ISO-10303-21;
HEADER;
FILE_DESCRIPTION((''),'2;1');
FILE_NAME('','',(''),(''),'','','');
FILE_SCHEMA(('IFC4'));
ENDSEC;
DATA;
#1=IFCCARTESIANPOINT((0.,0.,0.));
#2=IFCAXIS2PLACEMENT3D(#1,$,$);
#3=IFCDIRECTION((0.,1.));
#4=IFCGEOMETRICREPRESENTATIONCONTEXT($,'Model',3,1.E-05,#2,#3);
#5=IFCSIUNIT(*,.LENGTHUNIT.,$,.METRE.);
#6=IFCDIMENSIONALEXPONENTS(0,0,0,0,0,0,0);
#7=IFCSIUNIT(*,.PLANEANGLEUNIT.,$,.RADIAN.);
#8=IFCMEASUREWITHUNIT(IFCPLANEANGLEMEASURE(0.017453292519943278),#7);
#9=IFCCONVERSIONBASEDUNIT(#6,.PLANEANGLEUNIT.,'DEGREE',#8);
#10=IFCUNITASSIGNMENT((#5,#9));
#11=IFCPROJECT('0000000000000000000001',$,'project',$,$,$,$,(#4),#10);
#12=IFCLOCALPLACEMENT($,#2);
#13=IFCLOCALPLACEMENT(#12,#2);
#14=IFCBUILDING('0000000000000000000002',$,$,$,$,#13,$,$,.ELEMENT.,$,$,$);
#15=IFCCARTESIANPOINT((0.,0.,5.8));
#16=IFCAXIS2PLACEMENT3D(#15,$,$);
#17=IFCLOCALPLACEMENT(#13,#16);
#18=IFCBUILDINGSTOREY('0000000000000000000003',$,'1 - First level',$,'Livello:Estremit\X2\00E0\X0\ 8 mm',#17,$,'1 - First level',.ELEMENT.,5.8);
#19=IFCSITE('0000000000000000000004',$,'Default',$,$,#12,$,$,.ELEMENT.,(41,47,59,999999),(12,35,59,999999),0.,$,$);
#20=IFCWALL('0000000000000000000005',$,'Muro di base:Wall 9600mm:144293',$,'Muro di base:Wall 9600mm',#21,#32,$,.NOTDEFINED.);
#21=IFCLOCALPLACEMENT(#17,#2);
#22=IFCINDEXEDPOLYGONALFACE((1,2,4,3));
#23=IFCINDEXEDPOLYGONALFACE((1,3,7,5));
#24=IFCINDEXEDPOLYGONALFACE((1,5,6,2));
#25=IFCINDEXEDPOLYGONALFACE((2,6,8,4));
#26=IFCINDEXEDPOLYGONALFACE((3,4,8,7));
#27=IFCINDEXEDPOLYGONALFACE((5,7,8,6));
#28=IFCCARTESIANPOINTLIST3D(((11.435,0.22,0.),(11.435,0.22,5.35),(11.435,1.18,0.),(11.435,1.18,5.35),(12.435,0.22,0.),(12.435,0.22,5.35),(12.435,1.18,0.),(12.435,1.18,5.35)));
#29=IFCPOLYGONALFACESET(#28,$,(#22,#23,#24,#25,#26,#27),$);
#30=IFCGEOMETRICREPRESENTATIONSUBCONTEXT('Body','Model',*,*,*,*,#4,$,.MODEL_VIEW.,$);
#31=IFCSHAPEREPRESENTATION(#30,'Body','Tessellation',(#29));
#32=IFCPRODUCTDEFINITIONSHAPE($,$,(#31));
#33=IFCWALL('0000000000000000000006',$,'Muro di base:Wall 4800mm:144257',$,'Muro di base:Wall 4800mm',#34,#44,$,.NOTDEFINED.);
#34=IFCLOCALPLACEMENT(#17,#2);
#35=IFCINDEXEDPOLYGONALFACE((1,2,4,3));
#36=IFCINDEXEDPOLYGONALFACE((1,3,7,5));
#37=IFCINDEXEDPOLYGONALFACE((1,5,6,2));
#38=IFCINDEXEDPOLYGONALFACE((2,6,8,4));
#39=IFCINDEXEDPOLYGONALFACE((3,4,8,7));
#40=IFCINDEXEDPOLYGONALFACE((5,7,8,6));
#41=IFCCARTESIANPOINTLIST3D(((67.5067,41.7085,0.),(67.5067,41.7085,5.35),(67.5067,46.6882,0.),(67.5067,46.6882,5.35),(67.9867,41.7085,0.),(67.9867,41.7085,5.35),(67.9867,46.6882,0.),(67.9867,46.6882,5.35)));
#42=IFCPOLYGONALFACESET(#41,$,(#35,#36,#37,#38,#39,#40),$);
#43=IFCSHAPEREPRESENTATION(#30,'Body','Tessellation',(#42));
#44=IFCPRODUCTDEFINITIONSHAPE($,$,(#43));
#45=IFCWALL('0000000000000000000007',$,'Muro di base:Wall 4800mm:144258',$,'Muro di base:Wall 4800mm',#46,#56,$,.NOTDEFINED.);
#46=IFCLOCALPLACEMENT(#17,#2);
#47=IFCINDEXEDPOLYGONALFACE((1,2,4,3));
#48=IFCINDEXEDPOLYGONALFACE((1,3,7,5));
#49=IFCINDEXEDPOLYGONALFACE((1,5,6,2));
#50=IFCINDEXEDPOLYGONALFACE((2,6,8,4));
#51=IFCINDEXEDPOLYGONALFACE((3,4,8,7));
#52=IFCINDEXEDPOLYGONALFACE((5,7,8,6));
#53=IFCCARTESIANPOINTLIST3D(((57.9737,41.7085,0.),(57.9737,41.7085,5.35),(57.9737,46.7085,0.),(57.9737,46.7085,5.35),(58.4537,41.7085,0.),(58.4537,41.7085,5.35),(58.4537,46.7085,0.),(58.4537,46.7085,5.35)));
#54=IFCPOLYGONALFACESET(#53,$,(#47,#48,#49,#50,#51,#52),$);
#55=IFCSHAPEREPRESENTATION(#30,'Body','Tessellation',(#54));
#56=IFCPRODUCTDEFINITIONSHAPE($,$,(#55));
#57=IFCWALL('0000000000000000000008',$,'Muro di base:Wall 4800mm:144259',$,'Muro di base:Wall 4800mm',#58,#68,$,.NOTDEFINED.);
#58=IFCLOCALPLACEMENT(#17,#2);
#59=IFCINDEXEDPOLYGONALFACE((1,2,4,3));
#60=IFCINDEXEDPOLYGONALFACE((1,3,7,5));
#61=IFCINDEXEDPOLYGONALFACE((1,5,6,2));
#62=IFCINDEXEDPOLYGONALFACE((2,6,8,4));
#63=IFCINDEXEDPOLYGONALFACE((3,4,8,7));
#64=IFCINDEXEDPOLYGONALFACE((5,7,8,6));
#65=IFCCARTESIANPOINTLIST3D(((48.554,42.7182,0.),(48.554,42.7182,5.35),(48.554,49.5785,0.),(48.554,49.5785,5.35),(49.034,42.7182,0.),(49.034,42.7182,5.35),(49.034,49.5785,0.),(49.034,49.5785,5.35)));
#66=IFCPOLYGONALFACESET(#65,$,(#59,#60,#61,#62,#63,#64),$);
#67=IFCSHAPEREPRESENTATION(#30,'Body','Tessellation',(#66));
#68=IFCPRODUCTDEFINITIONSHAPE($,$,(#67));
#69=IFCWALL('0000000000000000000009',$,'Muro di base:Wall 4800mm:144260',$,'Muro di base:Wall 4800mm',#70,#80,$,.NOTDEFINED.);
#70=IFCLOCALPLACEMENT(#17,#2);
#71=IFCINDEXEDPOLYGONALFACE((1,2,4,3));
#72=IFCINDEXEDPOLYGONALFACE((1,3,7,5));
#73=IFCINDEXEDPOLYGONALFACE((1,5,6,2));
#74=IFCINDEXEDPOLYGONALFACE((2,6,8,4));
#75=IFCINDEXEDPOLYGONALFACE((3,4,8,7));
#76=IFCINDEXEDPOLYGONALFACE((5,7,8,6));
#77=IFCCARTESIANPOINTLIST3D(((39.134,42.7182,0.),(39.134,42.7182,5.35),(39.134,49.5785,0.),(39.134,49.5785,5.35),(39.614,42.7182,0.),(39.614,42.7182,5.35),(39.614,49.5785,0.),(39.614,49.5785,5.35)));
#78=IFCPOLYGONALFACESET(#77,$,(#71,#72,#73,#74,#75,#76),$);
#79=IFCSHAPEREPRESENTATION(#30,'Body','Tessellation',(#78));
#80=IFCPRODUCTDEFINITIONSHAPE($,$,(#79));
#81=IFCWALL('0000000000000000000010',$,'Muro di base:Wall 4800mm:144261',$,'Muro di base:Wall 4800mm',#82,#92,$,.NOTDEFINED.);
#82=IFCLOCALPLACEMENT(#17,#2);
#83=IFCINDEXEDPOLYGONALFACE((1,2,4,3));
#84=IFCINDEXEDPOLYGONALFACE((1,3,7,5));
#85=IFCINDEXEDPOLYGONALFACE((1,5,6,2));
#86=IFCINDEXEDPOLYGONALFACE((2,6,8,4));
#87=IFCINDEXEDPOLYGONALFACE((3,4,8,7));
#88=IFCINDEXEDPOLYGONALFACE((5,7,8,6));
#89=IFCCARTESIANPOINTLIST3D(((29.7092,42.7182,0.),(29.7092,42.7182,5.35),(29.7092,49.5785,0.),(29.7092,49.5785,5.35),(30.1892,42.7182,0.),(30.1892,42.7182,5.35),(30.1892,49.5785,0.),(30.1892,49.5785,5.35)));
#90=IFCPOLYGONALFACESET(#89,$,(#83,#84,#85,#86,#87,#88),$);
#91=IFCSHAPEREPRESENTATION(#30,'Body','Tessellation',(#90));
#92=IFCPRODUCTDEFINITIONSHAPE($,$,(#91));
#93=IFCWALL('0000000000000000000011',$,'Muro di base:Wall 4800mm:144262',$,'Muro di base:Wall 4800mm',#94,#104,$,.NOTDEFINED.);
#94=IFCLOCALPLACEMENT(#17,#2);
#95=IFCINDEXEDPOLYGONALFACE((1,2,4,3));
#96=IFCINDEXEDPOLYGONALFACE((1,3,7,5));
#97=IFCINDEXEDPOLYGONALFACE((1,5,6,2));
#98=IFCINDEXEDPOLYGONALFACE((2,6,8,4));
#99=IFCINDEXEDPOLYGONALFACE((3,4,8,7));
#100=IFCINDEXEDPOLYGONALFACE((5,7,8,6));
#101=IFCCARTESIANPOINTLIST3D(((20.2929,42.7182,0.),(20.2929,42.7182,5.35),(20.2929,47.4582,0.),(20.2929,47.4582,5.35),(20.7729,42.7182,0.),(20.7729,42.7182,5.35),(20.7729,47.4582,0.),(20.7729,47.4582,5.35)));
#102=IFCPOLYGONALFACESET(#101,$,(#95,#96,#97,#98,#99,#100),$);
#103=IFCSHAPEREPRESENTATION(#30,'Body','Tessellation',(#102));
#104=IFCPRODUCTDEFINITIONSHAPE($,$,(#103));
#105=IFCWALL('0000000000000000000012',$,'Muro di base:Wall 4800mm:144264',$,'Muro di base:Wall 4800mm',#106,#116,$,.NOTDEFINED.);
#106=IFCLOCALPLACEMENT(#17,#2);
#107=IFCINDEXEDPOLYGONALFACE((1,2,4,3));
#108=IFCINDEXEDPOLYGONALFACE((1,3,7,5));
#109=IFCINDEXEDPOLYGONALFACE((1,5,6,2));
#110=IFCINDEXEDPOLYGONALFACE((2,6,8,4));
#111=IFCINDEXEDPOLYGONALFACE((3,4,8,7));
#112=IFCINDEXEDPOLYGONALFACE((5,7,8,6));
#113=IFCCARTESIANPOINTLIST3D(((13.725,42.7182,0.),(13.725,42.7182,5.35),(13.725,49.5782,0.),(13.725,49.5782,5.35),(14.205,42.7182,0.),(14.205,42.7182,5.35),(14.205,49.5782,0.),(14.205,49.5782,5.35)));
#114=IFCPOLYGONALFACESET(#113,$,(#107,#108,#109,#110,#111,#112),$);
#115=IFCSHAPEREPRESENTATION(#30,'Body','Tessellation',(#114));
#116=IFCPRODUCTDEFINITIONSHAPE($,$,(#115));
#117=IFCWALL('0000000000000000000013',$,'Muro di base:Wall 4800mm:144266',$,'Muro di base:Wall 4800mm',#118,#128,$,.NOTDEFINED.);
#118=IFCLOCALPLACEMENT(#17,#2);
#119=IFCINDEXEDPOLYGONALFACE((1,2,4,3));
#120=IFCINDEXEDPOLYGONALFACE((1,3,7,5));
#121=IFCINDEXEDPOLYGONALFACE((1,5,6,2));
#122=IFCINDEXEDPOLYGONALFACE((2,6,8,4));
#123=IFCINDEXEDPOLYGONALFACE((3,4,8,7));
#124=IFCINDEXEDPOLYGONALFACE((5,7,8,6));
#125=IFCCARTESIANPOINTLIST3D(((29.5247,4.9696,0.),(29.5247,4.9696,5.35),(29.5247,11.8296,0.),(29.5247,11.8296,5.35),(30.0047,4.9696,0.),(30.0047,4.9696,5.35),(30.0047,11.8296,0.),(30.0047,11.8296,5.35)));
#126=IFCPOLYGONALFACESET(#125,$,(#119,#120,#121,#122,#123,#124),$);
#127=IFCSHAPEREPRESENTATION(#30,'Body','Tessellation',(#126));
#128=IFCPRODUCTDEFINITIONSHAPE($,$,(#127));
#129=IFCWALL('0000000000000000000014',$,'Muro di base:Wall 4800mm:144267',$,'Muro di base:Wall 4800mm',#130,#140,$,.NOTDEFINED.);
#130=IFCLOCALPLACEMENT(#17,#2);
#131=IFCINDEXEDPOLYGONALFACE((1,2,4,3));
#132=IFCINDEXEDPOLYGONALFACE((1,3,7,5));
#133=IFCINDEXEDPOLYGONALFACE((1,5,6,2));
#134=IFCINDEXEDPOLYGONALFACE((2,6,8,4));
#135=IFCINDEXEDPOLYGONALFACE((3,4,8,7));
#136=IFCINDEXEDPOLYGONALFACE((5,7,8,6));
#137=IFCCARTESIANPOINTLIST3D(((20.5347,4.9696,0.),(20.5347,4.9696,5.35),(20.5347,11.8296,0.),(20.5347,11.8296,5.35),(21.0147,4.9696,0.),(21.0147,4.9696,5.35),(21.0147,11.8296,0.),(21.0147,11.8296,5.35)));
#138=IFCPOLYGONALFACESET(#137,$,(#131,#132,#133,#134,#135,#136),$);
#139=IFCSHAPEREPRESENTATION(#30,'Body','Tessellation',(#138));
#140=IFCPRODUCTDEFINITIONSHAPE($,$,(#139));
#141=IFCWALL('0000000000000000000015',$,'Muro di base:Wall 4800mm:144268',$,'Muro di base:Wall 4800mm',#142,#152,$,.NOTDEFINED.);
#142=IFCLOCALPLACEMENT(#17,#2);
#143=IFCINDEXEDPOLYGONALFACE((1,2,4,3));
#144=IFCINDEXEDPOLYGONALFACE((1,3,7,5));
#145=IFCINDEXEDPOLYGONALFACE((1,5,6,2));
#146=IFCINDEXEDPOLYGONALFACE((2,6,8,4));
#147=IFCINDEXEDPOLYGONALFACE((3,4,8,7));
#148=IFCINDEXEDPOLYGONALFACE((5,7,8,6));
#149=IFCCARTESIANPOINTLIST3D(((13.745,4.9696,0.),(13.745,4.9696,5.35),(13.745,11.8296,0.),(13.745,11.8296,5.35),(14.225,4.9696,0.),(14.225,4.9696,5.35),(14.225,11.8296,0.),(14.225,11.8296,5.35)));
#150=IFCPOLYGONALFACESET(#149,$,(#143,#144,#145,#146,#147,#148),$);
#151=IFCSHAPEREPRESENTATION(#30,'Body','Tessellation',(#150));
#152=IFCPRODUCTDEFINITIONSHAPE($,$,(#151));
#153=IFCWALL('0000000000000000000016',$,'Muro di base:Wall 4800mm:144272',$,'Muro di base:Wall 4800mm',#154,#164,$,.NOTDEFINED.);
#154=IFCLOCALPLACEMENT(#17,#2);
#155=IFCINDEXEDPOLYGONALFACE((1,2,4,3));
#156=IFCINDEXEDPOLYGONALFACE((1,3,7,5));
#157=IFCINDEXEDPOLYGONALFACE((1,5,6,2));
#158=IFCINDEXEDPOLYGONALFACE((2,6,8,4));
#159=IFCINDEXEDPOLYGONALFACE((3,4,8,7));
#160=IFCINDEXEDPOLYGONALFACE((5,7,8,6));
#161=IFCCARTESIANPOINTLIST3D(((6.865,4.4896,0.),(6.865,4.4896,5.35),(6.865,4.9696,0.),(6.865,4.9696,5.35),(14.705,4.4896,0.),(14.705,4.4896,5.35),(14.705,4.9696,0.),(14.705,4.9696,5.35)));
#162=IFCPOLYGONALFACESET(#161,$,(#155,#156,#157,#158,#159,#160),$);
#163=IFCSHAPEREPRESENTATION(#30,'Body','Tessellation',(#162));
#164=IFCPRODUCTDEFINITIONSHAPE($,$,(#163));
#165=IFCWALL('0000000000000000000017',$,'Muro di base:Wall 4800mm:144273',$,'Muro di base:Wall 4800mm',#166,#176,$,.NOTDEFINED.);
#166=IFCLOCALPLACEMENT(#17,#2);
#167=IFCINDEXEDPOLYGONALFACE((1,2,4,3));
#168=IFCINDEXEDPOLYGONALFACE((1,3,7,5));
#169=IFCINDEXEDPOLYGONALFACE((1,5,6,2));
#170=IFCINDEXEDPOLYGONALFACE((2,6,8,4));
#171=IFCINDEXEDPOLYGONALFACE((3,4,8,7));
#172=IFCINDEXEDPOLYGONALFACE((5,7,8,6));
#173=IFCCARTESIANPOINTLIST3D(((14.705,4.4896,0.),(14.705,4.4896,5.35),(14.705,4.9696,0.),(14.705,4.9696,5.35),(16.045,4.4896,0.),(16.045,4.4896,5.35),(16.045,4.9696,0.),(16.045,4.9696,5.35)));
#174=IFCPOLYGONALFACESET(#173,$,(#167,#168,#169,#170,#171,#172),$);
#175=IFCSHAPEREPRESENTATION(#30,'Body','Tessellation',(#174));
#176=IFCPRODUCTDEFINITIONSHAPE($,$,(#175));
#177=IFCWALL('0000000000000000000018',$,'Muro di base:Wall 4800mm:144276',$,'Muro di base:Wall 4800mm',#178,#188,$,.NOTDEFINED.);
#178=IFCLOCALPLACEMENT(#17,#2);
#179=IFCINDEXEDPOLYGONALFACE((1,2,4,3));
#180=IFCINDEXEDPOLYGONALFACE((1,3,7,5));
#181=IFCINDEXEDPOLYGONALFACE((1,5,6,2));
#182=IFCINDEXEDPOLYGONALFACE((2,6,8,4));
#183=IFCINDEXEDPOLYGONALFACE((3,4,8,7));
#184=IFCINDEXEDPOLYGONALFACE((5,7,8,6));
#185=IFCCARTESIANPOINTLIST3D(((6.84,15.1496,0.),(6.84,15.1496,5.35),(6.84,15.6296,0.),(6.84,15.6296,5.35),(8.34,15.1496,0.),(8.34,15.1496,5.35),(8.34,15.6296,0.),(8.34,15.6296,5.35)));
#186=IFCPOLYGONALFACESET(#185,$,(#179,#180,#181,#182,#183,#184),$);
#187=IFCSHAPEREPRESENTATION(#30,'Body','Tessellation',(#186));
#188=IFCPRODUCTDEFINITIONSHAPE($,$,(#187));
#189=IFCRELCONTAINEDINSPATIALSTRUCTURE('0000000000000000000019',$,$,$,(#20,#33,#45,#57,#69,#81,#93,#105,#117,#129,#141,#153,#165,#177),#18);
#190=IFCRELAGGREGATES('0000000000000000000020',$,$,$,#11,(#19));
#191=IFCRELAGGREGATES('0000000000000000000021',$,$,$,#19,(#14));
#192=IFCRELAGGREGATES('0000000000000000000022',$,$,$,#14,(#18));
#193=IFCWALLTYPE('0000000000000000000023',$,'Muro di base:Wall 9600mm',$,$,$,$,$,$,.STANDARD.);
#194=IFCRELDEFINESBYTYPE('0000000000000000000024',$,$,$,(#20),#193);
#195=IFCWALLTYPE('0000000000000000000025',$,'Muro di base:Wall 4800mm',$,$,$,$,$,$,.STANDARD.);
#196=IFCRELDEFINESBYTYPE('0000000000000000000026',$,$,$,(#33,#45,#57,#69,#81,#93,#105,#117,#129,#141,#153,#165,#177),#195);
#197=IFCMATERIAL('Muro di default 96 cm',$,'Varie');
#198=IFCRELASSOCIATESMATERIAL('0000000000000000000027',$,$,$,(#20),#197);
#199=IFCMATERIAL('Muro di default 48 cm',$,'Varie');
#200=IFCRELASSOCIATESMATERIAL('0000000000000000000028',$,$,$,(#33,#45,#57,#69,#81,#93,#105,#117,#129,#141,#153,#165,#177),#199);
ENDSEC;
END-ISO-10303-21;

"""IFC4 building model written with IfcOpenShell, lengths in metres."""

from ifc_helpers import new_model, entity, si_unit, converted_unit, direction, frame, origin, place, context, subcontext, project, spatial, indexed_curve, outline, extrude, material, type_object, element, save


model = new_model("IFC4")

# Units and contexts
model_context = context("Model", 3, precision=1e-05, world=origin(), true_north=direction((0.0, 1.0)))
body_context = subcontext(model_context, "Body", "Model", "MODEL_VIEW")
ifc_project = project(units=[si_unit("LENGTHUNIT", "METRE"), converted_unit("PLANEANGLEUNIT", "DEGREE", entity("IfcPlaneAngleMeasure", 0.017453292519943278), si_unit("PLANEANGLEUNIT", "RADIAN"), dimensions=[0, 0, 0, 0, 0, 0, 0])], contexts=[model_context])

# Site, building, storey
site_placement = place(None, origin())
site = spatial("IfcSite", under=ifc_project, at=site_placement, Name="Default", CompositionType="ELEMENT", RefLatitude=(41, 47, 59, 999999), RefLongitude=(12, 35, 59, 999999), RefElevation=0.0)
building_placement = place(site_placement, origin())
building = spatial("IfcBuilding", under=site, at=building_placement, CompositionType="ELEMENT")
storey_placement = place(building_placement, frame((0.0, 0.0, 5.8)))
storey = spatial("IfcBuildingStorey", under=building, at=storey_placement, Name="1 - First level", ObjectType="Livello:Estremità 8 mm", LongName="1 - First level", CompositionType="ELEMENT", Elevation=5.8)

# Walls
ifc_material_1 = material(Name="Muro di default 96 cm", Category="Varie")
wall_type_1 = type_object("IfcWallType", Name="Muro di base:Wall 9600mm", PredefinedType="STANDARD")
wall_1_placement = place(storey_placement, frame((12.435, 0.7, 0.0), z_axis=(0.0, 0.0, 1.0), x_axis=(-1.0, 0.0, 0.0)))
element("IfcWall", 1, at=wall_1_placement, inside=storey, type_object=wall_type_1, material=ifc_material_1, Name="Muro di base:Wall 9600mm:144293", ObjectType="Muro di base:Wall 9600mm", PredefinedType="NOTDEFINED", context=body_context, shape_type="SweptSolid", body=[
    extrude(outline(indexed_curve([(1.0, 0.48), (0.0, 0.48), (0.0, -0.48), (1.0, -0.48), (1.0, 0.48)], self_intersect=False)), origin(), (0.0, 0.0, 1.0), 5.35),
])
ifc_material_2 = material(Name="Muro di default 48 cm", Category="Varie")
wall_type_2 = type_object("IfcWallType", Name="Muro di base:Wall 4800mm", PredefinedType="STANDARD")
wall_2_placement = place(storey_placement, frame((67.7467, 41.7085, 0.0), z_axis=(0.0, 0.0, 1.0), x_axis=(0.0, 1.0, 0.0)))
element("IfcWall", 2, at=wall_2_placement, inside=storey, type_object=wall_type_2, material=ifc_material_2, Name="Muro di base:Wall 4800mm:144257", ObjectType="Muro di base:Wall 4800mm", PredefinedType="NOTDEFINED", context=body_context, shape_type="SweptSolid", body=[
    extrude(outline(indexed_curve([(4.9797, 0.24), (0.0, 0.24), (0.0, -0.24), (4.9797, -0.24), (4.9797, 0.24)], self_intersect=False)), origin(), (0.0, 0.0, 1.0), 5.35),
])
wall_3_placement = place(storey_placement, frame((58.2137, 41.7085, 0.0), z_axis=(0.0, 0.0, 1.0), x_axis=(0.0, 1.0, 0.0)))
element("IfcWall", 3, at=wall_3_placement, inside=storey, type_object=wall_type_2, material=ifc_material_2, Name="Muro di base:Wall 4800mm:144258", ObjectType="Muro di base:Wall 4800mm", PredefinedType="NOTDEFINED", context=body_context, shape_type="SweptSolid", body=[
    extrude(outline(indexed_curve([(5.0, 0.24), (0.0, 0.24), (0.0, -0.24), (5.0, -0.24), (5.0, 0.24)], self_intersect=False)), origin(), (0.0, 0.0, 1.0), 5.35),
])
for number, where, z_axis, x_axis, name in (
    (4, (48.794, 42.7182, 0.0), (0.0, 0.0, 1.0), (0.0, 1.0, 0.0), "Muro di base:Wall 4800mm:144259"),
    (5, (39.374, 42.7182, 0.0), (0.0, 0.0, 1.0), (0.0, 1.0, 0.0), "Muro di base:Wall 4800mm:144260"),
):
    element("IfcWall", number, at=place(storey_placement, frame(where, z_axis=z_axis, x_axis=x_axis)), inside=storey, type_object=wall_type_2, material=ifc_material_2, Name=name, ObjectType="Muro di base:Wall 4800mm", PredefinedType="NOTDEFINED", context=body_context, shape_type="SweptSolid", body=[
        extrude(outline(indexed_curve([(6.8603, 0.24), (0.0, 0.24), (0.0, -0.24), (6.8603, -0.24), (6.8603, 0.24)], self_intersect=False)), origin(), (0.0, 0.0, 1.0), 5.35),
    ])
wall_4_placement = place(storey_placement, frame((29.9492, 42.7182, 0.0), z_axis=(0.0, 0.0, 1.0), x_axis=(0.0, 1.0, 0.0)))
element("IfcWall", 6, at=wall_4_placement, inside=storey, type_object=wall_type_2, material=ifc_material_2, Name="Muro di base:Wall 4800mm:144261", ObjectType="Muro di base:Wall 4800mm", PredefinedType="NOTDEFINED", context=body_context, shape_type="SweptSolid", body=[
    extrude(outline(indexed_curve([(6.8603, 0.24), (0.0, 0.24), (0.0, -0.24), (6.8603, -0.24), (6.8603, 0.24)], self_intersect=False)), origin(), (0.0, 0.0, 1.0), 5.35),
])
wall_5_placement = place(storey_placement, frame((20.5329, 42.7182, 0.0), z_axis=(0.0, 0.0, 1.0), x_axis=(0.0, 1.0, 0.0)))
element("IfcWall", 7, at=wall_5_placement, inside=storey, type_object=wall_type_2, material=ifc_material_2, Name="Muro di base:Wall 4800mm:144262", ObjectType="Muro di base:Wall 4800mm", PredefinedType="NOTDEFINED", context=body_context, shape_type="SweptSolid", body=[
    extrude(outline(indexed_curve([(4.74, 0.24), (0.0, 0.24), (0.0, -0.24), (4.74, -0.24), (4.74, 0.24)], self_intersect=False)), origin(), (0.0, 0.0, 1.0), 5.35),
])
wall_6_placement = place(storey_placement, frame((13.965, 42.7182, 0.0), z_axis=(0.0, 0.0, 1.0), x_axis=(0.0, 1.0, 0.0)))
element("IfcWall", 8, at=wall_6_placement, inside=storey, type_object=wall_type_2, material=ifc_material_2, Name="Muro di base:Wall 4800mm:144264", ObjectType="Muro di base:Wall 4800mm", PredefinedType="NOTDEFINED", context=body_context, shape_type="SweptSolid", body=[
    extrude(outline(indexed_curve([(6.86, 0.24), (0.0, 0.24), (0.0, -0.24), (6.86, -0.24), (6.86, 0.24)], self_intersect=False)), origin(), (0.0, 0.0, 1.0), 5.35),
])
for number, where, z_axis, x_axis, name in (
    (9, (29.7647, 4.9696, 0.0), (0.0, 0.0, 1.0), (0.0, 1.0, 0.0), "Muro di base:Wall 4800mm:144266"),
    (10, (20.7747, 4.9696, 0.0), (0.0, 0.0, 1.0), (0.0, 1.0, 0.0), "Muro di base:Wall 4800mm:144267"),
):
    element("IfcWall", number, at=place(storey_placement, frame(where, z_axis=z_axis, x_axis=x_axis)), inside=storey, type_object=wall_type_2, material=ifc_material_2, Name=name, ObjectType="Muro di base:Wall 4800mm", PredefinedType="NOTDEFINED", context=body_context, shape_type="SweptSolid", body=[
        extrude(outline(indexed_curve([(6.86, 0.24), (0.0, 0.24), (0.0, -0.24), (6.86, -0.24), (6.86, 0.24)], self_intersect=False)), origin(), (0.0, 0.0, 1.0), 5.35),
    ])
wall_7_placement = place(storey_placement, frame((13.985, 4.9696, 0.0), z_axis=(0.0, 0.0, 1.0), x_axis=(0.0, 1.0, 0.0)))
element("IfcWall", 11, at=wall_7_placement, inside=storey, type_object=wall_type_2, material=ifc_material_2, Name="Muro di base:Wall 4800mm:144268", ObjectType="Muro di base:Wall 4800mm", PredefinedType="NOTDEFINED", context=body_context, shape_type="SweptSolid", body=[
    extrude(outline(indexed_curve([(6.86, 0.24), (0.0, 0.24), (0.0, -0.24), (6.86, -0.24), (6.86, 0.24)], self_intersect=False)), origin(), (0.0, 0.0, 1.0), 5.35),
])
wall_8_placement = place(storey_placement, frame((6.865, 4.7296, 0.0)))
element("IfcWall", 12, at=wall_8_placement, inside=storey, type_object=wall_type_2, material=ifc_material_2, Name="Muro di base:Wall 4800mm:144272", ObjectType="Muro di base:Wall 4800mm", PredefinedType="NOTDEFINED", context=body_context, shape_type="SweptSolid", body=[
    extrude(outline(indexed_curve([(7.84, 0.24), (0.0, 0.24), (0.0, -0.24), (7.84, -0.24), (7.84, 0.24)], self_intersect=False)), origin(), (0.0, 0.0, 1.0), 5.35),
])
wall_9_placement = place(storey_placement, frame((14.705, 4.7296, 0.0)))
element("IfcWall", 13, at=wall_9_placement, inside=storey, type_object=wall_type_2, material=ifc_material_2, Name="Muro di base:Wall 4800mm:144273", ObjectType="Muro di base:Wall 4800mm", PredefinedType="NOTDEFINED", context=body_context, shape_type="SweptSolid", body=[
    extrude(outline(indexed_curve([(1.34, 0.24), (0.0, 0.24), (0.0, -0.24), (1.34, -0.24), (1.34, 0.24)], self_intersect=False)), origin(), (0.0, 0.0, 1.0), 5.35),
])
wall_10_placement = place(storey_placement, frame((6.84, 15.3896, 0.0)))
element("IfcWall", 14, at=wall_10_placement, inside=storey, type_object=wall_type_2, material=ifc_material_2, Name="Muro di base:Wall 4800mm:144276", ObjectType="Muro di base:Wall 4800mm", PredefinedType="NOTDEFINED", context=body_context, shape_type="SweptSolid", body=[
    extrude(outline(indexed_curve([(1.5, 0.24), (0.0, 0.24), (0.0, -0.24), (1.5, -0.24), (1.5, 0.24)], self_intersect=False)), origin(), (0.0, 0.0, 1.0), 5.35),
])

save(model, "model.ifc")
